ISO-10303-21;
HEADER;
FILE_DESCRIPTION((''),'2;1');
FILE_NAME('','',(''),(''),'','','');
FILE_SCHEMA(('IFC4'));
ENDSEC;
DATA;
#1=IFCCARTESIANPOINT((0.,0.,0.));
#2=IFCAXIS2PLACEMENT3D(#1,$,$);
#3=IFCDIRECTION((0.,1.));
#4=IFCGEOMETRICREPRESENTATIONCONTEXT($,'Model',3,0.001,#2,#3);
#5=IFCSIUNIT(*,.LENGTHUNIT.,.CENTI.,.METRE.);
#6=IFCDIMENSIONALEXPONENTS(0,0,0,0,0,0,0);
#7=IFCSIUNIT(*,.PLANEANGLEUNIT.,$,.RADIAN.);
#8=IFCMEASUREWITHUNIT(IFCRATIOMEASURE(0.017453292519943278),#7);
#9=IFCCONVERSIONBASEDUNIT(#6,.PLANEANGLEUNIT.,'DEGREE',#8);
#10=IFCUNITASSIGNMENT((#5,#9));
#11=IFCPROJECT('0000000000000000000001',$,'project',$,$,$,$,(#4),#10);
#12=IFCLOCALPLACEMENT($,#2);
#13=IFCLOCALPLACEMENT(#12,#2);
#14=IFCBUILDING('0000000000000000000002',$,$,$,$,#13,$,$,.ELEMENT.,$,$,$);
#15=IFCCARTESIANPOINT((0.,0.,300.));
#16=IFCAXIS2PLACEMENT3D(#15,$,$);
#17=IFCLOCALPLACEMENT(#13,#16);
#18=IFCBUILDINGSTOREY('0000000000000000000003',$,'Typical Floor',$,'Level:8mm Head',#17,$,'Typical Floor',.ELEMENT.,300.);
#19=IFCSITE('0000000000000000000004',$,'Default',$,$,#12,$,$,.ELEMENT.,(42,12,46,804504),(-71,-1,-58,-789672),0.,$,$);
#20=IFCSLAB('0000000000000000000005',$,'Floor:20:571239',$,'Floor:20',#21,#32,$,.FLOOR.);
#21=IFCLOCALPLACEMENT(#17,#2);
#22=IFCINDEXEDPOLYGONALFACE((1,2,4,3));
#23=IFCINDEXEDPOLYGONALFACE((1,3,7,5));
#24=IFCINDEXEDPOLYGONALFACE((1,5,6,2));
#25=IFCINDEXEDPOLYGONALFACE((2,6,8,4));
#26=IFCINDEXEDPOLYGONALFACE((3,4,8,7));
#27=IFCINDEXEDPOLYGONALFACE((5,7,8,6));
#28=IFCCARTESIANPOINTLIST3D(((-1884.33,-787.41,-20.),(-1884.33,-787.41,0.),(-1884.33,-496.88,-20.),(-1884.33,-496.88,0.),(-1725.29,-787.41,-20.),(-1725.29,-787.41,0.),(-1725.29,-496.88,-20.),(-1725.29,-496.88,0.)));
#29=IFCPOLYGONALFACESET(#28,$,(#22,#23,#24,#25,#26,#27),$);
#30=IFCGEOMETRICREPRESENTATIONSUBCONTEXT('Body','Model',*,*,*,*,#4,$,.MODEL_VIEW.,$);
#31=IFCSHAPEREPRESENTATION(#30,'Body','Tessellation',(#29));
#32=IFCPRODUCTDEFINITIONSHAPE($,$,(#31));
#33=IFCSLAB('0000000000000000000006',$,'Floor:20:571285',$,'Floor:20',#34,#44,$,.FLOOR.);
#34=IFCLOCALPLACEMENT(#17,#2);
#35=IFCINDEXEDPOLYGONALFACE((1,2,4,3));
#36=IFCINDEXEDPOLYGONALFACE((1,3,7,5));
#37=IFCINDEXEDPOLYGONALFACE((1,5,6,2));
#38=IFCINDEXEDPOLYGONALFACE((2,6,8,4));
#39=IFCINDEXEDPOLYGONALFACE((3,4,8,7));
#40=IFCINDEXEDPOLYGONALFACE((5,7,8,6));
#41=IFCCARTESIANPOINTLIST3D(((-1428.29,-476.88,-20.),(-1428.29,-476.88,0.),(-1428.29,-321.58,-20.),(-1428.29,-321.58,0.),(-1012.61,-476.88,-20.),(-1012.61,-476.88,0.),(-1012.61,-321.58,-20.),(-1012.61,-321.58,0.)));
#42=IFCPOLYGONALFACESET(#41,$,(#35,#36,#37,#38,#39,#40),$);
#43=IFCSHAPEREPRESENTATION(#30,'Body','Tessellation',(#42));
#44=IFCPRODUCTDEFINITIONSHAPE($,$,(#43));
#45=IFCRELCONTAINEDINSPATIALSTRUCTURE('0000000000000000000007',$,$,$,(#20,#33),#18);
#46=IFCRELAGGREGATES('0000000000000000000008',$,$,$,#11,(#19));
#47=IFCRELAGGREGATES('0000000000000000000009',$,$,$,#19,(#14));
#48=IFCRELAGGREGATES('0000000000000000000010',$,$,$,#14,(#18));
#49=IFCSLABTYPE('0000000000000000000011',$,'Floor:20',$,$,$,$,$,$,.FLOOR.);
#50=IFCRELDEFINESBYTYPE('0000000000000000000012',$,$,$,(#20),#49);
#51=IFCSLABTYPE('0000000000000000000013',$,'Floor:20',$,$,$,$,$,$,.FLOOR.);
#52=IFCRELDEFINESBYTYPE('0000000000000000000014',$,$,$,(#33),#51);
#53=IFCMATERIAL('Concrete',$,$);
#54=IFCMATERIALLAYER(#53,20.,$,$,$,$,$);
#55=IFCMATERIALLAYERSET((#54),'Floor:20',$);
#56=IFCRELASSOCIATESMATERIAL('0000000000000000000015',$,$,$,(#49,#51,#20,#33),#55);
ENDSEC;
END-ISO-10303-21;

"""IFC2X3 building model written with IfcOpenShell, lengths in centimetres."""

from ifc_helpers import new_model, entity, si_unit, converted_unit, direction, frame, frame_2d, origin, place, context, subcontext, project, spatial, rectangle, extrude, material, layer, layer_set, layer_usage, type_object, element, save


model = new_model("IFC2X3")

# Units and contexts
model_context = context("Model", 3, precision=0.001, world=origin(), true_north=direction((0.0, 1.0)))
body_context = subcontext(model_context, "Body", "Model", "MODEL_VIEW")
ifc_project = project(units=[si_unit("LENGTHUNIT", "METRE", prefix="CENTI"), converted_unit("PLANEANGLEUNIT", "DEGREE", entity("IfcRatioMeasure", 0.017453292519943278), si_unit("PLANEANGLEUNIT", "RADIAN"), dimensions=[0, 0, 0, 0, 0, 0, 0])], contexts=[model_context])

# Site, building, storey
site_placement = place(None, origin())
site = spatial("IfcSite", under=ifc_project, at=site_placement, Name="Default", CompositionType="ELEMENT", RefLatitude=(42, 12, 46, 804504), RefLongitude=(-71, -1, -58, -789672), RefElevation=0.0)
building_placement = place(site_placement, origin())
building = spatial("IfcBuilding", under=site, at=building_placement, CompositionType="ELEMENT")
storey_placement = place(building_placement, frame((0.0, 0.0, 300.0)))
storey = spatial("IfcBuildingStorey", under=building, at=storey_placement, Name="Typical Floor", ObjectType="Level:8mm Head", LongName="Typical Floor", CompositionType="ELEMENT", Elevation=300.0)

# Shared definitions
ifc_material = material(Name="Concrete")

# Slabs
ifc_layer_1 = layer(ifc_material, 20.0)
ifc_layer_set_1 = layer_set([ifc_layer_1], Name="Floor:20")
ifc_layer_usage_1 = layer_usage(ifc_layer_set_1, "AXIS3", "POSITIVE", 0.0)
slab_type_1 = type_object("IfcSlabType", Name="Floor:20", PredefinedType="FLOOR", material=ifc_layer_set_1)
slab_1_placement = place(storey_placement, origin())
element("IfcSlab", 1, at=slab_1_placement, inside=storey, type_object=slab_type_1, material=ifc_layer_usage_1, Name="Floor:20:571239", ObjectType="Floor:20", PredefinedType="FLOOR", context=body_context, shape_type="SweptSolid", body=[
    extrude(rectangle(XDim=290.53, YDim=159.04, at=frame_2d((0.0, 0.0), x_axis=(1.0, 0.0))), frame((-1804.81, -642.14, 0.0), z_axis=(0.0, 0.0, -1.0), x_axis=(0.0, 1.0, 0.0)), (0.0, 0.0, 1.0), 20.0),
])
ifc_layer_usage_2 = layer_usage(ifc_layer_set_1, "AXIS3", "POSITIVE", 0.0)
slab_type_2 = type_object("IfcSlabType", Name="Floor:20", PredefinedType="FLOOR", material=ifc_layer_set_1)
slab_2_placement = place(storey_placement, origin())
element("IfcSlab", 2, at=slab_2_placement, inside=storey, type_object=slab_type_2, material=ifc_layer_usage_2, Name="Floor:20:571285", ObjectType="Floor:20", PredefinedType="FLOOR", context=body_context, shape_type="SweptSolid", body=[
    extrude(rectangle(XDim=155.29, YDim=415.68, at=frame_2d((0.0, 0.0), x_axis=(1.0, 0.0))), frame((-1220.45, -399.23, 0.0), z_axis=(0.0, 0.0, -1.0), x_axis=(0.0, 1.0, 0.0)), (0.0, 0.0, 1.0), 20.0),
])

save(model, "model.ifc")
